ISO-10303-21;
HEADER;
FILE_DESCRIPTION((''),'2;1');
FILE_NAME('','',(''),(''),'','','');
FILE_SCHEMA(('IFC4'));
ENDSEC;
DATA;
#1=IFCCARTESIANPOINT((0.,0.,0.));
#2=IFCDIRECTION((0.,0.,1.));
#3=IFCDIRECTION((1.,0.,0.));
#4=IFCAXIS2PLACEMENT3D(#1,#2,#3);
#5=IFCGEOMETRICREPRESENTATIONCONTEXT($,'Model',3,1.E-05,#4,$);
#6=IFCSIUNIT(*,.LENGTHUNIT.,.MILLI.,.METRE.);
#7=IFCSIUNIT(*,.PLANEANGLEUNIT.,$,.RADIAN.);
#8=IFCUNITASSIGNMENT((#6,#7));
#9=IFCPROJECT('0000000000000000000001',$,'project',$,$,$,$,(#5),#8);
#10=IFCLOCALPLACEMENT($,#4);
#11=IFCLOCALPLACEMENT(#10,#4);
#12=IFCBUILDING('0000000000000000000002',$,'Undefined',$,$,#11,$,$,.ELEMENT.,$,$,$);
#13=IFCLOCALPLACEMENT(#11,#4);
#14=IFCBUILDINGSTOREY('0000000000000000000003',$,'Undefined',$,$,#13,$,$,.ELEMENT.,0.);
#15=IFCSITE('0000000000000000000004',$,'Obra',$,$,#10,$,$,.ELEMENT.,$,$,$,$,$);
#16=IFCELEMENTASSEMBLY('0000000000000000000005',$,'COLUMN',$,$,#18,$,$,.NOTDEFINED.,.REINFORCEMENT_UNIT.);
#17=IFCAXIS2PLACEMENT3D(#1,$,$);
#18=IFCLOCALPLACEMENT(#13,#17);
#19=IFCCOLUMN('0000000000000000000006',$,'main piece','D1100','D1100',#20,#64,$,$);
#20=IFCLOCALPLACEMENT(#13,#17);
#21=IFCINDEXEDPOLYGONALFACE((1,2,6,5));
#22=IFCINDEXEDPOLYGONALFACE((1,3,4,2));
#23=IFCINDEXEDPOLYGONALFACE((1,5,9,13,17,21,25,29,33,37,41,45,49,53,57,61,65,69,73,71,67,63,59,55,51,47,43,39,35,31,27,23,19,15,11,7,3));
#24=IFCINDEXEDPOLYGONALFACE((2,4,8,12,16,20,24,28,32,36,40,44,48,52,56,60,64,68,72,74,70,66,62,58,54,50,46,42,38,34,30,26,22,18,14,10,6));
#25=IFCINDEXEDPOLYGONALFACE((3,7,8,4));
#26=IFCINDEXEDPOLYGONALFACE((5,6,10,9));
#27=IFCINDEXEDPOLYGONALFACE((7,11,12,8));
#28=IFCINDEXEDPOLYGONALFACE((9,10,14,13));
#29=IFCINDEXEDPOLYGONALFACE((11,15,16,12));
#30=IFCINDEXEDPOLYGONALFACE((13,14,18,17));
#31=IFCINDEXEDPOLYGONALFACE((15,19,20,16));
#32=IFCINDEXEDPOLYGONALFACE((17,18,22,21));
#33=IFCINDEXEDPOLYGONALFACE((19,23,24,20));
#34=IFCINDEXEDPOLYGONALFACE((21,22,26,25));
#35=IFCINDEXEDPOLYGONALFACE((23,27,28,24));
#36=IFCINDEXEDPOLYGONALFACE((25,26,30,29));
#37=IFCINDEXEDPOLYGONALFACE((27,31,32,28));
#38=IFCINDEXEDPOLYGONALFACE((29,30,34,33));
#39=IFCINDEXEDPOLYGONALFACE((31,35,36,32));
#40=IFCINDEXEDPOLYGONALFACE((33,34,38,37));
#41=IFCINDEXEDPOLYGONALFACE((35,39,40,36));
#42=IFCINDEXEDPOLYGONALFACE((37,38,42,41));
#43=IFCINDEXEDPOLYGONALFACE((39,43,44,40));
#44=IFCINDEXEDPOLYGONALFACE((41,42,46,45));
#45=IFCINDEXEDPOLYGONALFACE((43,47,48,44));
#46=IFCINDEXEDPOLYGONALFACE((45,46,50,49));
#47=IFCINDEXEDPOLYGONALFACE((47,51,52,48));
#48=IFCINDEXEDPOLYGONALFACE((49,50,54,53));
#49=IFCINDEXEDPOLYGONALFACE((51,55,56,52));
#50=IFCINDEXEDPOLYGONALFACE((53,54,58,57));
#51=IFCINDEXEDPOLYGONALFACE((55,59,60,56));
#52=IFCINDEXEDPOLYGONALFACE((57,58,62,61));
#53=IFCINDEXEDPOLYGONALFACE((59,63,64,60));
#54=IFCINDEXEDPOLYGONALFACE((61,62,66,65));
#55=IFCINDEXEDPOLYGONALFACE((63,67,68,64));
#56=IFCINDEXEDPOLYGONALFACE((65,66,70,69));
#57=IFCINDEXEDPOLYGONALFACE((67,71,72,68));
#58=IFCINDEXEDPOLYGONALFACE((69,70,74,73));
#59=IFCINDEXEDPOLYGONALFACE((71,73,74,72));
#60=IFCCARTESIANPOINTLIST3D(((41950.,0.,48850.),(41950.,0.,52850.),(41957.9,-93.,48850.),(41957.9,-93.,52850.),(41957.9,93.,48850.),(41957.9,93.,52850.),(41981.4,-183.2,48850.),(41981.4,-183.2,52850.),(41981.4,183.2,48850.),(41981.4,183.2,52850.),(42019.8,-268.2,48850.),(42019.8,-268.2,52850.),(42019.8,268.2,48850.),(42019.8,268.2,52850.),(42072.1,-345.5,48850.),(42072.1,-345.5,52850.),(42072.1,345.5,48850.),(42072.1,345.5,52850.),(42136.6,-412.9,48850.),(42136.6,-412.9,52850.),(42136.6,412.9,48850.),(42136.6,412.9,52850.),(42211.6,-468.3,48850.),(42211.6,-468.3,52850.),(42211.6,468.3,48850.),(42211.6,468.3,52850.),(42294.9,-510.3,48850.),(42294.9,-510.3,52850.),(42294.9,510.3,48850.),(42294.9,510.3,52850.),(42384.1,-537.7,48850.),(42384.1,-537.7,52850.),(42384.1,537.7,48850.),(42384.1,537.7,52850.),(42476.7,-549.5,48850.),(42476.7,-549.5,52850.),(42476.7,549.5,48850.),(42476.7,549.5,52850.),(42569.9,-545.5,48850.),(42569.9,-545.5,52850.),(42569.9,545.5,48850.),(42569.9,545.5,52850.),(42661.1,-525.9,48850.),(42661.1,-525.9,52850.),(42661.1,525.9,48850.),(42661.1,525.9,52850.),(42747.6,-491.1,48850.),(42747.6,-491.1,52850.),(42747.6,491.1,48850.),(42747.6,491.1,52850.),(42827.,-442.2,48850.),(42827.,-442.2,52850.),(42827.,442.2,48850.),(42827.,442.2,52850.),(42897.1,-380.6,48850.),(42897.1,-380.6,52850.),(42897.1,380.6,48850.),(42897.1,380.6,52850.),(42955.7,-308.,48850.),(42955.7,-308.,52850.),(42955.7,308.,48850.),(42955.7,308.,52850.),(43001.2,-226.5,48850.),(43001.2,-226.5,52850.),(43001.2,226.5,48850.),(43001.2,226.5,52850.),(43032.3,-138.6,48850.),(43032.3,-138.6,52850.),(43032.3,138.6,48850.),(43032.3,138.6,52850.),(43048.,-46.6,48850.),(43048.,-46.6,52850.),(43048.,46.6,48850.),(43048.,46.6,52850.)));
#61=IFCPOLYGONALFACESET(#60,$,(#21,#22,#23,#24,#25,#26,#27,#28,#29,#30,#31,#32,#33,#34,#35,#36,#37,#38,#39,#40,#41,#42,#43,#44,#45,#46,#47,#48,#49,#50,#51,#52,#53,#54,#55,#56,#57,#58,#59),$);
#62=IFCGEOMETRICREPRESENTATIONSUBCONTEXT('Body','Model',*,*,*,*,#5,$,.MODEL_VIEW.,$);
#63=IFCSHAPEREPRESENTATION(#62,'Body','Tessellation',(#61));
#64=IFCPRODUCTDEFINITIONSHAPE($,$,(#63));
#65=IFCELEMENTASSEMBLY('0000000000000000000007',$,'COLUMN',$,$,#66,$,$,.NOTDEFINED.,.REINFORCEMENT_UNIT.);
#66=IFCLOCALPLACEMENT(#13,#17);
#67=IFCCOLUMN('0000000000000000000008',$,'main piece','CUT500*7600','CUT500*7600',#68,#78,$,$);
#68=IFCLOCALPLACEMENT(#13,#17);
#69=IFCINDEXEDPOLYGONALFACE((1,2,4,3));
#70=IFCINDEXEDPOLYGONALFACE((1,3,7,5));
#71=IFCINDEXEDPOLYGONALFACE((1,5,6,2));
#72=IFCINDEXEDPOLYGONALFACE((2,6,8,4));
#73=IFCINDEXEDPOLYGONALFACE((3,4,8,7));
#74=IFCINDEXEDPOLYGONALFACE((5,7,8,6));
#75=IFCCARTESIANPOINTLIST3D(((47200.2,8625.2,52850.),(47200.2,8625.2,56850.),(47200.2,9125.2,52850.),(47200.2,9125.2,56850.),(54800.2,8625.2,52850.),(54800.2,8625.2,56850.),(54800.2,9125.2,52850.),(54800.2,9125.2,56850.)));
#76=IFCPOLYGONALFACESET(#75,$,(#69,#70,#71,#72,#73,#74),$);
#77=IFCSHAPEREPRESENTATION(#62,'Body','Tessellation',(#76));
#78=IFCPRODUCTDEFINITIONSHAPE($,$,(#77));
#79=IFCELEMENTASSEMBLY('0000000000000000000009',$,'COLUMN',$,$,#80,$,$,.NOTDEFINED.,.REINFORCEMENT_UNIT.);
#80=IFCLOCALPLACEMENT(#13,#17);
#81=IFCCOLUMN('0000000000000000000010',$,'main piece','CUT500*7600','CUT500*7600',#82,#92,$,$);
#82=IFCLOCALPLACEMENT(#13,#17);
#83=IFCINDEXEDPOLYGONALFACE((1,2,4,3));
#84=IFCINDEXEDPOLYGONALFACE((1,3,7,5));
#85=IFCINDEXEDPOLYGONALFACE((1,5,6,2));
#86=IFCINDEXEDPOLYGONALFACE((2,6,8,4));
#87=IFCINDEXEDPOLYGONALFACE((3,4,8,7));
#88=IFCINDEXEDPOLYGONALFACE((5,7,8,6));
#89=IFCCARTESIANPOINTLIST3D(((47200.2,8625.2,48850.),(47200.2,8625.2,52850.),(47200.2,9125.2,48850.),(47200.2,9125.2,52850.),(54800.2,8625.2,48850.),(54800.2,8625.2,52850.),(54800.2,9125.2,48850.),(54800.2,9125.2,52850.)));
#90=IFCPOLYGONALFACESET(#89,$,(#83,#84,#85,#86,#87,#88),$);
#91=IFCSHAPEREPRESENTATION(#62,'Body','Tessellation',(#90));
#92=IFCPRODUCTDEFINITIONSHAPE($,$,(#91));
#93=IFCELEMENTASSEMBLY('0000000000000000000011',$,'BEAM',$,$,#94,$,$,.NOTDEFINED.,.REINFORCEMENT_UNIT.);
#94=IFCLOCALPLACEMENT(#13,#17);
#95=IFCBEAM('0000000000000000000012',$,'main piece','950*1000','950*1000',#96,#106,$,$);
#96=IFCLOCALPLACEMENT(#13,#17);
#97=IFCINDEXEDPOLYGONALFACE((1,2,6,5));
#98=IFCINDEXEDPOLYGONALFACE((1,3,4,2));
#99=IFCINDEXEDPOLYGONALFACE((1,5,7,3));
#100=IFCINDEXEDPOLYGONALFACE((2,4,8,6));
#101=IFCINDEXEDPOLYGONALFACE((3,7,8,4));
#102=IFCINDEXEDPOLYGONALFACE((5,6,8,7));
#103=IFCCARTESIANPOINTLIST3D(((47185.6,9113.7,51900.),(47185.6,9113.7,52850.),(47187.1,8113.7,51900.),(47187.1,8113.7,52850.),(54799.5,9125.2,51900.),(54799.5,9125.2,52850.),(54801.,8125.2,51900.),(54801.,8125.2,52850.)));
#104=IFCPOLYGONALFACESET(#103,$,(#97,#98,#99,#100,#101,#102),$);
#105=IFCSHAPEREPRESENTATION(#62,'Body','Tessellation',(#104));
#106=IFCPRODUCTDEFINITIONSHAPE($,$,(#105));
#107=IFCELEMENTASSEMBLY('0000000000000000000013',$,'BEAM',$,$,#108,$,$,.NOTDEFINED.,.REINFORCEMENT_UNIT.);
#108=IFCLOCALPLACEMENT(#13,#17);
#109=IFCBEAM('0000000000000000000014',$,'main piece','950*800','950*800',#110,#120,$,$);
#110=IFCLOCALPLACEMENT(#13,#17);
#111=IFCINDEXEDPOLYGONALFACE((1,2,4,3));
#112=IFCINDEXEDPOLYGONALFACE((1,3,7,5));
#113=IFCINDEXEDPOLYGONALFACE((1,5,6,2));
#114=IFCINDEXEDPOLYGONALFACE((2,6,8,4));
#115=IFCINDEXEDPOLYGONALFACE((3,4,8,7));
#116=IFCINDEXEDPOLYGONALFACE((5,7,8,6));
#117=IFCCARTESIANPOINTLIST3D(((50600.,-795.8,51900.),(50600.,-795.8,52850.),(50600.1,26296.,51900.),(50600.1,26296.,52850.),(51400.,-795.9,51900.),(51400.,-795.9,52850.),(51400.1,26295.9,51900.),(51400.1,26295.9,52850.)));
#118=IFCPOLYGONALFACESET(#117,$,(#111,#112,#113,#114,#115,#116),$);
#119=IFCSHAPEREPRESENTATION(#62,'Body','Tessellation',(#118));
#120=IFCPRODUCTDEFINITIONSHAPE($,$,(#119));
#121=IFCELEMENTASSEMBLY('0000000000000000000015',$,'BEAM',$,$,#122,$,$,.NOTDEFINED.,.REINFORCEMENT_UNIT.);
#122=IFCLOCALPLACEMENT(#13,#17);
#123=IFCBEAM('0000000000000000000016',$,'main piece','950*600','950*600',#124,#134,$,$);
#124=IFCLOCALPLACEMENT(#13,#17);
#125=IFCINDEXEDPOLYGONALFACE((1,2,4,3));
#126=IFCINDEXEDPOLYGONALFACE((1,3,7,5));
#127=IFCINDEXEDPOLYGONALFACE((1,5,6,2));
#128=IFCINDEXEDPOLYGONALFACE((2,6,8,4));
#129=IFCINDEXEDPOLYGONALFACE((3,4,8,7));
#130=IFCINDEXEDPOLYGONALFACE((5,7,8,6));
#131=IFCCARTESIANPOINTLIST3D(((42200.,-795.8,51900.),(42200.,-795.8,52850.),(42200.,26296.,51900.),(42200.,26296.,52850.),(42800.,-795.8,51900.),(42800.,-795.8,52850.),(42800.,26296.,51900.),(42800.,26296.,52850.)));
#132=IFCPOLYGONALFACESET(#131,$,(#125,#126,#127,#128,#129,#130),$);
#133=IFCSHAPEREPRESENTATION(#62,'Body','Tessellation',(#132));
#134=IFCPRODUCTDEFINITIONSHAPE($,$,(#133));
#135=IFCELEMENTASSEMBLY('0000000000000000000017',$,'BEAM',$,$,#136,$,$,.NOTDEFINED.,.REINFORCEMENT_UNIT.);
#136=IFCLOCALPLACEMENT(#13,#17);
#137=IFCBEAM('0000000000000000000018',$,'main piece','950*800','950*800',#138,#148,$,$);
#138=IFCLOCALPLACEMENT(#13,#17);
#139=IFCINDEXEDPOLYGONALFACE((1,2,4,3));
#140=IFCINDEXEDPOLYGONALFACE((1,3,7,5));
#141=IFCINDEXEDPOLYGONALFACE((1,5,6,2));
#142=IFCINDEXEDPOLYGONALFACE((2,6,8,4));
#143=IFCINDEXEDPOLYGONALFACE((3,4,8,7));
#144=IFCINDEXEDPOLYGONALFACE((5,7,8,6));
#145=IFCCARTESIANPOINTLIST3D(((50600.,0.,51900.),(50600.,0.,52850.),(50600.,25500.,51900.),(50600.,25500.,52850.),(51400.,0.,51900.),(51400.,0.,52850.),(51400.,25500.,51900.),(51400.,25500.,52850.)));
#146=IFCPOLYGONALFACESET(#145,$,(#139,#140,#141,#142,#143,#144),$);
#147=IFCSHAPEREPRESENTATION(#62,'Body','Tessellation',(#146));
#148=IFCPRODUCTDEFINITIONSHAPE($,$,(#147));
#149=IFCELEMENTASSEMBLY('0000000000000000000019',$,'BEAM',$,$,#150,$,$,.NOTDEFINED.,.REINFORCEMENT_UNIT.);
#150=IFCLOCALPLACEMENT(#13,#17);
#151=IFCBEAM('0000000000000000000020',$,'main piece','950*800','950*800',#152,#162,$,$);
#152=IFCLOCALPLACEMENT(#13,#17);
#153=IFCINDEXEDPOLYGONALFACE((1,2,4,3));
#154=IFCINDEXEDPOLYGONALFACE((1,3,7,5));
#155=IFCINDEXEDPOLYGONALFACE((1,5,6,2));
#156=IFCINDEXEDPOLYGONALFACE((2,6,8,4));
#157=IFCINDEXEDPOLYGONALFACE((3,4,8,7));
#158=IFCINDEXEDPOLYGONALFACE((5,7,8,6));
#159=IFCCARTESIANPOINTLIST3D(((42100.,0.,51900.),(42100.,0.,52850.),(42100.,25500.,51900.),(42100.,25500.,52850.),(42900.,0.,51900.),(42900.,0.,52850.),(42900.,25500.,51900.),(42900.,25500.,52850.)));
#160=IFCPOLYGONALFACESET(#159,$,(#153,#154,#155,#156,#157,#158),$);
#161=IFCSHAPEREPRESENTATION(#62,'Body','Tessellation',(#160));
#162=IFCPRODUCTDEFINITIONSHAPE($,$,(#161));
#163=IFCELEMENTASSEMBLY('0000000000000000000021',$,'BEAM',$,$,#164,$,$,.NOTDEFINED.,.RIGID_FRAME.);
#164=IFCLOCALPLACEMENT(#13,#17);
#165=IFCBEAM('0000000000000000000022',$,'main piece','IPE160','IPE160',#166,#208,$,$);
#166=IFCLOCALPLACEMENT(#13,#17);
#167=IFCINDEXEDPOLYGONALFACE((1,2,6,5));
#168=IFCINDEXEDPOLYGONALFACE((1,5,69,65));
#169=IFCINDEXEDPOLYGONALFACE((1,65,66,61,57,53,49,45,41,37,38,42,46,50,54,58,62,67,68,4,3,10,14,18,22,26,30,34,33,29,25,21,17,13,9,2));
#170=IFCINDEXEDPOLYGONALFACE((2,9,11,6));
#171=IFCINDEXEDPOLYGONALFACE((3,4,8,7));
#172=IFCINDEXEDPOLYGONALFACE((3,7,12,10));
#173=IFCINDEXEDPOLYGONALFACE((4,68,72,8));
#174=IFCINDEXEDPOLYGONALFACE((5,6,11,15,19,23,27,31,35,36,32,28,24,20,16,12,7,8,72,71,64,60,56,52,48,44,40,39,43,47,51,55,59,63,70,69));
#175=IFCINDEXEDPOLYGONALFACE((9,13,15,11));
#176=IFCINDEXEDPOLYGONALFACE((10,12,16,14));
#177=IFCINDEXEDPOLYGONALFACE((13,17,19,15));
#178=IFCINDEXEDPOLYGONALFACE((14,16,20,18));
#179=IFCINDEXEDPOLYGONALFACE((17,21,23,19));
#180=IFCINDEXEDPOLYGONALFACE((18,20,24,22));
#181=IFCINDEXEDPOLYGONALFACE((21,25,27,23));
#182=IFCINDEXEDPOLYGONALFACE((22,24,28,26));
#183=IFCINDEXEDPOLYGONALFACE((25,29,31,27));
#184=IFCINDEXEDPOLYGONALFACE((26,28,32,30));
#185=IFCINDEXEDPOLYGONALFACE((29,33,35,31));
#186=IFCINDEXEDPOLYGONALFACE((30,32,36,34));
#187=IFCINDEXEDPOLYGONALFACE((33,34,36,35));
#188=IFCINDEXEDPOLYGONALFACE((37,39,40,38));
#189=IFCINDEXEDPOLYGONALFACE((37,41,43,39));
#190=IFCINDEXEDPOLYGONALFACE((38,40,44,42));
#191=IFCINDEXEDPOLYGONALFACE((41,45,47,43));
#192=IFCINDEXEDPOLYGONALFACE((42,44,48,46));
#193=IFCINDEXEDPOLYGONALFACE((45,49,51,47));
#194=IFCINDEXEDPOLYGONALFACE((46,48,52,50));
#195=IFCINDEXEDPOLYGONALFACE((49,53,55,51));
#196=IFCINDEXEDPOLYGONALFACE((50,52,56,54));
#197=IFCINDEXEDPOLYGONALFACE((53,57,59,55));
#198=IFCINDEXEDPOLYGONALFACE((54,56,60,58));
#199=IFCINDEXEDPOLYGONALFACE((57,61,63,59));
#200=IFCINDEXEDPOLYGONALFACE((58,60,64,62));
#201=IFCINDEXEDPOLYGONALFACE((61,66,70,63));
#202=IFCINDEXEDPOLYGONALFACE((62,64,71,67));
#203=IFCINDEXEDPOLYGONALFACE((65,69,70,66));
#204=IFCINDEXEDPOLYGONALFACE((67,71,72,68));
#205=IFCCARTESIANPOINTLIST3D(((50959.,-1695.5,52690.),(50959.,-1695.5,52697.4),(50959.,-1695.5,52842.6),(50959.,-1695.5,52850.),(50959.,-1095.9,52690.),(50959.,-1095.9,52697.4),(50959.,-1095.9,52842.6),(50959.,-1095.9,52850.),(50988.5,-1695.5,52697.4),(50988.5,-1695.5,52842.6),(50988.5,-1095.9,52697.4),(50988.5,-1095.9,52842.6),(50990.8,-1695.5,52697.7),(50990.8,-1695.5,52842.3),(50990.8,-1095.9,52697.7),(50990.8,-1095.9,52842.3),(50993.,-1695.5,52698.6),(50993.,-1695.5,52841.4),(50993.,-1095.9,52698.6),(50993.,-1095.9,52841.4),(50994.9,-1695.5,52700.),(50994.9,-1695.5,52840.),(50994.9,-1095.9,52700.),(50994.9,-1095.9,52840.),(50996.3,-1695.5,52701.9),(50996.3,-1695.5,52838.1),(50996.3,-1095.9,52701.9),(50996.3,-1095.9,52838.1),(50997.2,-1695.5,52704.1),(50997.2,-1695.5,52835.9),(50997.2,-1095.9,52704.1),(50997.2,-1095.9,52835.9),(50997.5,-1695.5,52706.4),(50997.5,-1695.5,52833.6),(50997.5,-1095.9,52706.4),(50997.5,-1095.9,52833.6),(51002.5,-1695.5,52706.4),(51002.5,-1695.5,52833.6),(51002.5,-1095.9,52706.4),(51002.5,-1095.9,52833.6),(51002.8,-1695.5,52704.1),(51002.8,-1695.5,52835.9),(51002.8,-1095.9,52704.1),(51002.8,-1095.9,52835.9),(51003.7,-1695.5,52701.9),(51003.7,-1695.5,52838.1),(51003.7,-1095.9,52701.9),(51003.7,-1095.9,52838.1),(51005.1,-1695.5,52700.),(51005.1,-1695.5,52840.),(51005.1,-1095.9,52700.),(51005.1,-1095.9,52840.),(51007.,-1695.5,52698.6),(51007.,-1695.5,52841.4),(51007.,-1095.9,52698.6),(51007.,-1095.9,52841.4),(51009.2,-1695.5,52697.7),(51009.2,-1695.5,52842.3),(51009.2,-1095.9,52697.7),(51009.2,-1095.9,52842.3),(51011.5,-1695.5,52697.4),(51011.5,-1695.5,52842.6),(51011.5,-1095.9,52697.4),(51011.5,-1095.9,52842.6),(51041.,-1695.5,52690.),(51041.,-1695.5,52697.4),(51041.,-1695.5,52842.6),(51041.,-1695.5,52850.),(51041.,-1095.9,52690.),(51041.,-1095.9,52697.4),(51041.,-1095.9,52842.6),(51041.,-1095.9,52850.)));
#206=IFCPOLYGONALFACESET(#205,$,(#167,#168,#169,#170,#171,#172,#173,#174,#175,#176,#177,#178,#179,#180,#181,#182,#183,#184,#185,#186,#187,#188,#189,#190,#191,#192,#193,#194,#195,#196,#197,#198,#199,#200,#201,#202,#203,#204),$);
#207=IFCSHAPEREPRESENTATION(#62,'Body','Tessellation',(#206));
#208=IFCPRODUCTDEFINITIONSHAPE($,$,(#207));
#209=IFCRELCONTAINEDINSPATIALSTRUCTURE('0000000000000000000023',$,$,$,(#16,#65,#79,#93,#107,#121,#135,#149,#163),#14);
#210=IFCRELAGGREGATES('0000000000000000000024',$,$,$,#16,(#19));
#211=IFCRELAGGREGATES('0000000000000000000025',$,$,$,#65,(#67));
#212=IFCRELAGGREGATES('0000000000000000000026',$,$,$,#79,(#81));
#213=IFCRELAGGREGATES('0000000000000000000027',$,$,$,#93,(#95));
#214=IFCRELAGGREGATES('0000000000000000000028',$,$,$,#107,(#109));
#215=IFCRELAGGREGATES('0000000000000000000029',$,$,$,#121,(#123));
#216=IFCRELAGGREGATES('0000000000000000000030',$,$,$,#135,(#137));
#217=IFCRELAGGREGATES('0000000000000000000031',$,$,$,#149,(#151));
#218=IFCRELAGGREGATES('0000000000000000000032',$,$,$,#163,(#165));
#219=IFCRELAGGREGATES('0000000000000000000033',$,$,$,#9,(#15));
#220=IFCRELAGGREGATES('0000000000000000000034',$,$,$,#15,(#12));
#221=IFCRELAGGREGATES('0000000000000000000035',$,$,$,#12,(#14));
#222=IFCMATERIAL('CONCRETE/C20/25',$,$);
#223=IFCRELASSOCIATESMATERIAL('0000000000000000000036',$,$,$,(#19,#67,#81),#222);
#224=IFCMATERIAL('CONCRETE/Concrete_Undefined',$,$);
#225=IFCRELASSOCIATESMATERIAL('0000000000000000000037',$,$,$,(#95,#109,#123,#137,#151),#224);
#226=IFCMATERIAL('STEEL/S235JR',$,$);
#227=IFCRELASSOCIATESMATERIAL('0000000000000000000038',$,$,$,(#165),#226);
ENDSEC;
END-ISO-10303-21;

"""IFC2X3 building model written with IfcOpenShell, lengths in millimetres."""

from ifc_helpers import new_model, si_unit, frame, origin_with_axes, origin_2d_with_axis, place, context, subcontext, project, spatial, rectangle, circle, i_section, extrude, material, element, aggregate, save


model = new_model("IFC2X3")

# Units and contexts
model_context = context("Model", 3, precision=1e-05, world=origin_with_axes())
body_context = subcontext(model_context, "Body", "Model", "MODEL_VIEW")
ifc_project = project(units=[si_unit("LENGTHUNIT", "METRE", prefix="MILLI"), si_unit("PLANEANGLEUNIT", "RADIAN")], contexts=[model_context])

# Site, building, storey
site_placement = place(None, origin_with_axes())
site = spatial("IfcSite", under=ifc_project, at=site_placement, Name="Obra", CompositionType="ELEMENT")
building_placement = place(site_placement, origin_with_axes())
building = spatial("IfcBuilding", under=site, at=building_placement, Name="Undefined", CompositionType="ELEMENT")
storey_placement = place(building_placement, origin_with_axes())
storey = spatial("IfcBuildingStorey", under=building, at=storey_placement, Name="Undefined", CompositionType="ELEMENT", Elevation=0.0)

# Element assemblies, columns
ifc_material_1 = material(Name="STEEL/S235JR")
ifc_material_2 = material(Name="CONCRETE/C20/25")
assembly_1_placement = place(storey_placement, origin_with_axes())
assembly_1 = element("IfcElementAssembly", 1, at=assembly_1_placement, inside=storey, Name="COLUMN", AssemblyPlace="NOTDEFINED", PredefinedType="REINFORCEMENT_UNIT")
column_1_placement = place(assembly_1_placement, frame((42500.0, 0.0, 48850.0), z_axis=(0.0, 0.0, 1.0), x_axis=(0.0, 1.0, 0.0)))
column_1 = element("IfcColumn", 2, at=column_1_placement, material=ifc_material_2, Name="main piece", Description="D1100", ObjectType="D1100", context=body_context, shape_type="SweptSolid", body=[
    extrude(circle(Radius=550.0, at=origin_2d_with_axis()), frame((0.0, 0.0, 4000.0), z_axis=(0.0, 0.0, -1.0), x_axis=(0.0, 1.0, 0.0)), (0.0, 0.0, 1.0), 4000.0),
])
aggregate(assembly_1, [column_1])
assembly_2_placement = place(storey_placement, origin_with_axes())
assembly_2 = element("IfcElementAssembly", 3, at=assembly_2_placement, inside=storey, Name="COLUMN", AssemblyPlace="NOTDEFINED", PredefinedType="REINFORCEMENT_UNIT")
column_2_placement = place(assembly_2_placement, frame((51000.2, 8875.2, 52850.0), z_axis=(0.0, 0.0, 1.0), x_axis=(-1.0, 0.0, 0.0)))
column_2 = element("IfcColumn", 4, at=column_2_placement, material=ifc_material_2, Name="main piece", Description="CUT500*7600", ObjectType="CUT500*7600", context=body_context, shape_type="SweptSolid", body=[
    extrude(rectangle(XDim=500.0, YDim=7600.0, at=origin_2d_with_axis()), frame((0.0, 0.0, 4000.0), z_axis=(0.0, 0.0, -1.0), x_axis=(0.0, 1.0, 0.0)), (0.0, 0.0, 1.0), 4000.0),
])
aggregate(assembly_2, [column_2])
assembly_3_placement = place(storey_placement, origin_with_axes())
assembly_3 = element("IfcElementAssembly", 5, at=assembly_3_placement, inside=storey, Name="COLUMN", AssemblyPlace="NOTDEFINED", PredefinedType="REINFORCEMENT_UNIT")
column_3_placement = place(assembly_3_placement, frame((51000.2, 8875.2, 48850.0), z_axis=(0.0, 0.0, 1.0), x_axis=(-1.0, 0.0, 0.0)))
column_3 = element("IfcColumn", 6, at=column_3_placement, material=ifc_material_2, Name="main piece", Description="CUT500*7600", ObjectType="CUT500*7600", context=body_context, shape_type="SweptSolid", body=[
    extrude(rectangle(XDim=500.0, YDim=7600.0, at=origin_2d_with_axis()), frame((0.0, 0.0, 4000.0), z_axis=(0.0, 0.0, -1.0), x_axis=(0.0, 1.0, 0.0)), (0.0, 0.0, 1.0), 4000.0),
])
aggregate(assembly_3, [column_3])

# Element assemblies, beams
assembly_4_placement = place(storey_placement, origin_with_axes())
assembly_4 = element("IfcElementAssembly", 7, at=assembly_4_placement, inside=storey, Name="BEAM", AssemblyPlace="NOTDEFINED", PredefinedType="REINFORCEMENT_UNIT")
ifc_material_3 = material(Name="CONCRETE/Concrete_Undefined")
beam_1_placement = place(assembly_4_placement, frame((47186.4, 8613.7, 52375.0), z_axis=(0.0, 0.0, 1.0), x_axis=(0.999999, 0.001508, 0.0)))
beam_1 = element("IfcBeam", 8, at=beam_1_placement, material=ifc_material_3, Name="main piece", Description="950*1000", ObjectType="950*1000", context=body_context, shape_type="SweptSolid", body=[
    extrude(rectangle(XDim=1000.0, YDim=950.0, at=origin_2d_with_axis()), frame((7613.8, 0.0, 0.0), z_axis=(-1.0, 0.0, 0.0), x_axis=(0.0, -1.0, 0.0)), (0.0, 0.0, 1.0), 7613.8),
])
aggregate(assembly_4, [beam_1])
assembly_5_placement = place(storey_placement, origin_with_axes())
assembly_5 = element("IfcElementAssembly", 9, at=assembly_5_placement, inside=storey, Name="BEAM", AssemblyPlace="NOTDEFINED", PredefinedType="REINFORCEMENT_UNIT")
beam_2_placement = place(assembly_5_placement, frame((51000.0, -795.8, 52375.0), z_axis=(0.0, 0.0, 1.0), x_axis=(0.000003, 1.0, 0.0)))
beam_2 = element("IfcBeam", 10, at=beam_2_placement, material=ifc_material_3, Name="main piece", Description="950*800", ObjectType="950*800", context=body_context, shape_type="SweptSolid", body=[
    extrude(rectangle(XDim=800.0, YDim=950.0, at=origin_2d_with_axis()), frame((27091.8, 0.0, 0.0), z_axis=(-1.0, 0.0, 0.0), x_axis=(0.0, -1.0, 0.0)), (0.0, 0.0, 1.0), 27091.8),
])
aggregate(assembly_5, [beam_2])
assembly_6_placement = place(storey_placement, origin_with_axes())
assembly_6 = element("IfcElementAssembly", 11, at=assembly_6_placement, inside=storey, Name="BEAM", AssemblyPlace="NOTDEFINED", PredefinedType="REINFORCEMENT_UNIT")
beam_3_placement = place(assembly_6_placement, frame((42500.0, -795.8, 52375.0), z_axis=(0.0, 0.0, 1.0), x_axis=(0.0, 1.0, 0.0)))
beam_3 = element("IfcBeam", 12, at=beam_3_placement, material=ifc_material_3, Name="main piece", Description="950*600", ObjectType="950*600", context=body_context, shape_type="SweptSolid", body=[
    extrude(rectangle(XDim=600.0, YDim=950.0, at=origin_2d_with_axis()), frame((27091.8, 0.0, 0.0), z_axis=(-1.0, 0.0, 0.0), x_axis=(0.0, -1.0, 0.0)), (0.0, 0.0, 1.0), 27091.8),
])
aggregate(assembly_6, [beam_3])
assembly_7_placement = place(storey_placement, origin_with_axes())
assembly_7 = element("IfcElementAssembly", 13, at=assembly_7_placement, inside=storey, Name="BEAM", AssemblyPlace="NOTDEFINED", PredefinedType="REINFORCEMENT_UNIT")
beam_4_placement = place(assembly_7_placement, frame((51000.0, 0.0, 52375.0), z_axis=(0.0, 0.0, 1.0), x_axis=(0.0, 1.0, 0.0)))
beam_4 = element("IfcBeam", 14, at=beam_4_placement, material=ifc_material_3, Name="main piece", Description="950*800", ObjectType="950*800", context=body_context, shape_type="SweptSolid", body=[
    extrude(rectangle(XDim=800.0, YDim=950.0, at=origin_2d_with_axis()), frame((25500.0, 0.0, 0.0), z_axis=(-1.0, 0.0, 0.0), x_axis=(0.0, -1.0, 0.0)), (0.0, 0.0, 1.0), 25500.0),
])
aggregate(assembly_7, [beam_4])
assembly_8_placement = place(storey_placement, origin_with_axes())
assembly_8 = element("IfcElementAssembly", 15, at=assembly_8_placement, inside=storey, Name="BEAM", AssemblyPlace="NOTDEFINED", PredefinedType="REINFORCEMENT_UNIT")
beam_5_placement = place(assembly_8_placement, frame((42500.0, 0.0, 52375.0), z_axis=(0.0, 0.0, 1.0), x_axis=(0.0, 1.0, 0.0)))
beam_5 = element("IfcBeam", 16, at=beam_5_placement, material=ifc_material_3, Name="main piece", Description="950*800", ObjectType="950*800", context=body_context, shape_type="SweptSolid", body=[
    extrude(rectangle(XDim=800.0, YDim=950.0, at=origin_2d_with_axis()), frame((25500.0, 0.0, 0.0), z_axis=(-1.0, 0.0, 0.0), x_axis=(0.0, -1.0, 0.0)), (0.0, 0.0, 1.0), 25500.0),
])
aggregate(assembly_8, [beam_5])
assembly_9_placement = place(storey_placement, origin_with_axes())
assembly_9 = element("IfcElementAssembly", 17, at=assembly_9_placement, inside=storey, Name="BEAM", AssemblyPlace="NOTDEFINED", PredefinedType="RIGID_FRAME")
beam_6_placement = place(assembly_9_placement, frame((51000.0, -1095.9, 52770.0), z_axis=(0.0, 0.0, 1.0), x_axis=(0.000002, -1.0, 0.0)))
beam_6 = element("IfcBeam", 18, at=beam_6_placement, material=ifc_material_1, Name="main piece", Description="IPE160", ObjectType="IPE160", context=body_context, shape_type="SweptSolid", body=[
    extrude(i_section(OverallWidth=82.0, OverallDepth=160.0, WebThickness=5.0, FlangeThickness=7.4, FilletRadius=9.0, at=origin_2d_with_axis()), frame((599.6, 0.0, 0.0), z_axis=(-1.0, 0.0, 0.0), x_axis=(0.0, -1.0, 0.0)), (0.0, 0.0, 1.0), 599.6),
])
aggregate(assembly_9, [beam_6])

save(model, "model.ifc")
